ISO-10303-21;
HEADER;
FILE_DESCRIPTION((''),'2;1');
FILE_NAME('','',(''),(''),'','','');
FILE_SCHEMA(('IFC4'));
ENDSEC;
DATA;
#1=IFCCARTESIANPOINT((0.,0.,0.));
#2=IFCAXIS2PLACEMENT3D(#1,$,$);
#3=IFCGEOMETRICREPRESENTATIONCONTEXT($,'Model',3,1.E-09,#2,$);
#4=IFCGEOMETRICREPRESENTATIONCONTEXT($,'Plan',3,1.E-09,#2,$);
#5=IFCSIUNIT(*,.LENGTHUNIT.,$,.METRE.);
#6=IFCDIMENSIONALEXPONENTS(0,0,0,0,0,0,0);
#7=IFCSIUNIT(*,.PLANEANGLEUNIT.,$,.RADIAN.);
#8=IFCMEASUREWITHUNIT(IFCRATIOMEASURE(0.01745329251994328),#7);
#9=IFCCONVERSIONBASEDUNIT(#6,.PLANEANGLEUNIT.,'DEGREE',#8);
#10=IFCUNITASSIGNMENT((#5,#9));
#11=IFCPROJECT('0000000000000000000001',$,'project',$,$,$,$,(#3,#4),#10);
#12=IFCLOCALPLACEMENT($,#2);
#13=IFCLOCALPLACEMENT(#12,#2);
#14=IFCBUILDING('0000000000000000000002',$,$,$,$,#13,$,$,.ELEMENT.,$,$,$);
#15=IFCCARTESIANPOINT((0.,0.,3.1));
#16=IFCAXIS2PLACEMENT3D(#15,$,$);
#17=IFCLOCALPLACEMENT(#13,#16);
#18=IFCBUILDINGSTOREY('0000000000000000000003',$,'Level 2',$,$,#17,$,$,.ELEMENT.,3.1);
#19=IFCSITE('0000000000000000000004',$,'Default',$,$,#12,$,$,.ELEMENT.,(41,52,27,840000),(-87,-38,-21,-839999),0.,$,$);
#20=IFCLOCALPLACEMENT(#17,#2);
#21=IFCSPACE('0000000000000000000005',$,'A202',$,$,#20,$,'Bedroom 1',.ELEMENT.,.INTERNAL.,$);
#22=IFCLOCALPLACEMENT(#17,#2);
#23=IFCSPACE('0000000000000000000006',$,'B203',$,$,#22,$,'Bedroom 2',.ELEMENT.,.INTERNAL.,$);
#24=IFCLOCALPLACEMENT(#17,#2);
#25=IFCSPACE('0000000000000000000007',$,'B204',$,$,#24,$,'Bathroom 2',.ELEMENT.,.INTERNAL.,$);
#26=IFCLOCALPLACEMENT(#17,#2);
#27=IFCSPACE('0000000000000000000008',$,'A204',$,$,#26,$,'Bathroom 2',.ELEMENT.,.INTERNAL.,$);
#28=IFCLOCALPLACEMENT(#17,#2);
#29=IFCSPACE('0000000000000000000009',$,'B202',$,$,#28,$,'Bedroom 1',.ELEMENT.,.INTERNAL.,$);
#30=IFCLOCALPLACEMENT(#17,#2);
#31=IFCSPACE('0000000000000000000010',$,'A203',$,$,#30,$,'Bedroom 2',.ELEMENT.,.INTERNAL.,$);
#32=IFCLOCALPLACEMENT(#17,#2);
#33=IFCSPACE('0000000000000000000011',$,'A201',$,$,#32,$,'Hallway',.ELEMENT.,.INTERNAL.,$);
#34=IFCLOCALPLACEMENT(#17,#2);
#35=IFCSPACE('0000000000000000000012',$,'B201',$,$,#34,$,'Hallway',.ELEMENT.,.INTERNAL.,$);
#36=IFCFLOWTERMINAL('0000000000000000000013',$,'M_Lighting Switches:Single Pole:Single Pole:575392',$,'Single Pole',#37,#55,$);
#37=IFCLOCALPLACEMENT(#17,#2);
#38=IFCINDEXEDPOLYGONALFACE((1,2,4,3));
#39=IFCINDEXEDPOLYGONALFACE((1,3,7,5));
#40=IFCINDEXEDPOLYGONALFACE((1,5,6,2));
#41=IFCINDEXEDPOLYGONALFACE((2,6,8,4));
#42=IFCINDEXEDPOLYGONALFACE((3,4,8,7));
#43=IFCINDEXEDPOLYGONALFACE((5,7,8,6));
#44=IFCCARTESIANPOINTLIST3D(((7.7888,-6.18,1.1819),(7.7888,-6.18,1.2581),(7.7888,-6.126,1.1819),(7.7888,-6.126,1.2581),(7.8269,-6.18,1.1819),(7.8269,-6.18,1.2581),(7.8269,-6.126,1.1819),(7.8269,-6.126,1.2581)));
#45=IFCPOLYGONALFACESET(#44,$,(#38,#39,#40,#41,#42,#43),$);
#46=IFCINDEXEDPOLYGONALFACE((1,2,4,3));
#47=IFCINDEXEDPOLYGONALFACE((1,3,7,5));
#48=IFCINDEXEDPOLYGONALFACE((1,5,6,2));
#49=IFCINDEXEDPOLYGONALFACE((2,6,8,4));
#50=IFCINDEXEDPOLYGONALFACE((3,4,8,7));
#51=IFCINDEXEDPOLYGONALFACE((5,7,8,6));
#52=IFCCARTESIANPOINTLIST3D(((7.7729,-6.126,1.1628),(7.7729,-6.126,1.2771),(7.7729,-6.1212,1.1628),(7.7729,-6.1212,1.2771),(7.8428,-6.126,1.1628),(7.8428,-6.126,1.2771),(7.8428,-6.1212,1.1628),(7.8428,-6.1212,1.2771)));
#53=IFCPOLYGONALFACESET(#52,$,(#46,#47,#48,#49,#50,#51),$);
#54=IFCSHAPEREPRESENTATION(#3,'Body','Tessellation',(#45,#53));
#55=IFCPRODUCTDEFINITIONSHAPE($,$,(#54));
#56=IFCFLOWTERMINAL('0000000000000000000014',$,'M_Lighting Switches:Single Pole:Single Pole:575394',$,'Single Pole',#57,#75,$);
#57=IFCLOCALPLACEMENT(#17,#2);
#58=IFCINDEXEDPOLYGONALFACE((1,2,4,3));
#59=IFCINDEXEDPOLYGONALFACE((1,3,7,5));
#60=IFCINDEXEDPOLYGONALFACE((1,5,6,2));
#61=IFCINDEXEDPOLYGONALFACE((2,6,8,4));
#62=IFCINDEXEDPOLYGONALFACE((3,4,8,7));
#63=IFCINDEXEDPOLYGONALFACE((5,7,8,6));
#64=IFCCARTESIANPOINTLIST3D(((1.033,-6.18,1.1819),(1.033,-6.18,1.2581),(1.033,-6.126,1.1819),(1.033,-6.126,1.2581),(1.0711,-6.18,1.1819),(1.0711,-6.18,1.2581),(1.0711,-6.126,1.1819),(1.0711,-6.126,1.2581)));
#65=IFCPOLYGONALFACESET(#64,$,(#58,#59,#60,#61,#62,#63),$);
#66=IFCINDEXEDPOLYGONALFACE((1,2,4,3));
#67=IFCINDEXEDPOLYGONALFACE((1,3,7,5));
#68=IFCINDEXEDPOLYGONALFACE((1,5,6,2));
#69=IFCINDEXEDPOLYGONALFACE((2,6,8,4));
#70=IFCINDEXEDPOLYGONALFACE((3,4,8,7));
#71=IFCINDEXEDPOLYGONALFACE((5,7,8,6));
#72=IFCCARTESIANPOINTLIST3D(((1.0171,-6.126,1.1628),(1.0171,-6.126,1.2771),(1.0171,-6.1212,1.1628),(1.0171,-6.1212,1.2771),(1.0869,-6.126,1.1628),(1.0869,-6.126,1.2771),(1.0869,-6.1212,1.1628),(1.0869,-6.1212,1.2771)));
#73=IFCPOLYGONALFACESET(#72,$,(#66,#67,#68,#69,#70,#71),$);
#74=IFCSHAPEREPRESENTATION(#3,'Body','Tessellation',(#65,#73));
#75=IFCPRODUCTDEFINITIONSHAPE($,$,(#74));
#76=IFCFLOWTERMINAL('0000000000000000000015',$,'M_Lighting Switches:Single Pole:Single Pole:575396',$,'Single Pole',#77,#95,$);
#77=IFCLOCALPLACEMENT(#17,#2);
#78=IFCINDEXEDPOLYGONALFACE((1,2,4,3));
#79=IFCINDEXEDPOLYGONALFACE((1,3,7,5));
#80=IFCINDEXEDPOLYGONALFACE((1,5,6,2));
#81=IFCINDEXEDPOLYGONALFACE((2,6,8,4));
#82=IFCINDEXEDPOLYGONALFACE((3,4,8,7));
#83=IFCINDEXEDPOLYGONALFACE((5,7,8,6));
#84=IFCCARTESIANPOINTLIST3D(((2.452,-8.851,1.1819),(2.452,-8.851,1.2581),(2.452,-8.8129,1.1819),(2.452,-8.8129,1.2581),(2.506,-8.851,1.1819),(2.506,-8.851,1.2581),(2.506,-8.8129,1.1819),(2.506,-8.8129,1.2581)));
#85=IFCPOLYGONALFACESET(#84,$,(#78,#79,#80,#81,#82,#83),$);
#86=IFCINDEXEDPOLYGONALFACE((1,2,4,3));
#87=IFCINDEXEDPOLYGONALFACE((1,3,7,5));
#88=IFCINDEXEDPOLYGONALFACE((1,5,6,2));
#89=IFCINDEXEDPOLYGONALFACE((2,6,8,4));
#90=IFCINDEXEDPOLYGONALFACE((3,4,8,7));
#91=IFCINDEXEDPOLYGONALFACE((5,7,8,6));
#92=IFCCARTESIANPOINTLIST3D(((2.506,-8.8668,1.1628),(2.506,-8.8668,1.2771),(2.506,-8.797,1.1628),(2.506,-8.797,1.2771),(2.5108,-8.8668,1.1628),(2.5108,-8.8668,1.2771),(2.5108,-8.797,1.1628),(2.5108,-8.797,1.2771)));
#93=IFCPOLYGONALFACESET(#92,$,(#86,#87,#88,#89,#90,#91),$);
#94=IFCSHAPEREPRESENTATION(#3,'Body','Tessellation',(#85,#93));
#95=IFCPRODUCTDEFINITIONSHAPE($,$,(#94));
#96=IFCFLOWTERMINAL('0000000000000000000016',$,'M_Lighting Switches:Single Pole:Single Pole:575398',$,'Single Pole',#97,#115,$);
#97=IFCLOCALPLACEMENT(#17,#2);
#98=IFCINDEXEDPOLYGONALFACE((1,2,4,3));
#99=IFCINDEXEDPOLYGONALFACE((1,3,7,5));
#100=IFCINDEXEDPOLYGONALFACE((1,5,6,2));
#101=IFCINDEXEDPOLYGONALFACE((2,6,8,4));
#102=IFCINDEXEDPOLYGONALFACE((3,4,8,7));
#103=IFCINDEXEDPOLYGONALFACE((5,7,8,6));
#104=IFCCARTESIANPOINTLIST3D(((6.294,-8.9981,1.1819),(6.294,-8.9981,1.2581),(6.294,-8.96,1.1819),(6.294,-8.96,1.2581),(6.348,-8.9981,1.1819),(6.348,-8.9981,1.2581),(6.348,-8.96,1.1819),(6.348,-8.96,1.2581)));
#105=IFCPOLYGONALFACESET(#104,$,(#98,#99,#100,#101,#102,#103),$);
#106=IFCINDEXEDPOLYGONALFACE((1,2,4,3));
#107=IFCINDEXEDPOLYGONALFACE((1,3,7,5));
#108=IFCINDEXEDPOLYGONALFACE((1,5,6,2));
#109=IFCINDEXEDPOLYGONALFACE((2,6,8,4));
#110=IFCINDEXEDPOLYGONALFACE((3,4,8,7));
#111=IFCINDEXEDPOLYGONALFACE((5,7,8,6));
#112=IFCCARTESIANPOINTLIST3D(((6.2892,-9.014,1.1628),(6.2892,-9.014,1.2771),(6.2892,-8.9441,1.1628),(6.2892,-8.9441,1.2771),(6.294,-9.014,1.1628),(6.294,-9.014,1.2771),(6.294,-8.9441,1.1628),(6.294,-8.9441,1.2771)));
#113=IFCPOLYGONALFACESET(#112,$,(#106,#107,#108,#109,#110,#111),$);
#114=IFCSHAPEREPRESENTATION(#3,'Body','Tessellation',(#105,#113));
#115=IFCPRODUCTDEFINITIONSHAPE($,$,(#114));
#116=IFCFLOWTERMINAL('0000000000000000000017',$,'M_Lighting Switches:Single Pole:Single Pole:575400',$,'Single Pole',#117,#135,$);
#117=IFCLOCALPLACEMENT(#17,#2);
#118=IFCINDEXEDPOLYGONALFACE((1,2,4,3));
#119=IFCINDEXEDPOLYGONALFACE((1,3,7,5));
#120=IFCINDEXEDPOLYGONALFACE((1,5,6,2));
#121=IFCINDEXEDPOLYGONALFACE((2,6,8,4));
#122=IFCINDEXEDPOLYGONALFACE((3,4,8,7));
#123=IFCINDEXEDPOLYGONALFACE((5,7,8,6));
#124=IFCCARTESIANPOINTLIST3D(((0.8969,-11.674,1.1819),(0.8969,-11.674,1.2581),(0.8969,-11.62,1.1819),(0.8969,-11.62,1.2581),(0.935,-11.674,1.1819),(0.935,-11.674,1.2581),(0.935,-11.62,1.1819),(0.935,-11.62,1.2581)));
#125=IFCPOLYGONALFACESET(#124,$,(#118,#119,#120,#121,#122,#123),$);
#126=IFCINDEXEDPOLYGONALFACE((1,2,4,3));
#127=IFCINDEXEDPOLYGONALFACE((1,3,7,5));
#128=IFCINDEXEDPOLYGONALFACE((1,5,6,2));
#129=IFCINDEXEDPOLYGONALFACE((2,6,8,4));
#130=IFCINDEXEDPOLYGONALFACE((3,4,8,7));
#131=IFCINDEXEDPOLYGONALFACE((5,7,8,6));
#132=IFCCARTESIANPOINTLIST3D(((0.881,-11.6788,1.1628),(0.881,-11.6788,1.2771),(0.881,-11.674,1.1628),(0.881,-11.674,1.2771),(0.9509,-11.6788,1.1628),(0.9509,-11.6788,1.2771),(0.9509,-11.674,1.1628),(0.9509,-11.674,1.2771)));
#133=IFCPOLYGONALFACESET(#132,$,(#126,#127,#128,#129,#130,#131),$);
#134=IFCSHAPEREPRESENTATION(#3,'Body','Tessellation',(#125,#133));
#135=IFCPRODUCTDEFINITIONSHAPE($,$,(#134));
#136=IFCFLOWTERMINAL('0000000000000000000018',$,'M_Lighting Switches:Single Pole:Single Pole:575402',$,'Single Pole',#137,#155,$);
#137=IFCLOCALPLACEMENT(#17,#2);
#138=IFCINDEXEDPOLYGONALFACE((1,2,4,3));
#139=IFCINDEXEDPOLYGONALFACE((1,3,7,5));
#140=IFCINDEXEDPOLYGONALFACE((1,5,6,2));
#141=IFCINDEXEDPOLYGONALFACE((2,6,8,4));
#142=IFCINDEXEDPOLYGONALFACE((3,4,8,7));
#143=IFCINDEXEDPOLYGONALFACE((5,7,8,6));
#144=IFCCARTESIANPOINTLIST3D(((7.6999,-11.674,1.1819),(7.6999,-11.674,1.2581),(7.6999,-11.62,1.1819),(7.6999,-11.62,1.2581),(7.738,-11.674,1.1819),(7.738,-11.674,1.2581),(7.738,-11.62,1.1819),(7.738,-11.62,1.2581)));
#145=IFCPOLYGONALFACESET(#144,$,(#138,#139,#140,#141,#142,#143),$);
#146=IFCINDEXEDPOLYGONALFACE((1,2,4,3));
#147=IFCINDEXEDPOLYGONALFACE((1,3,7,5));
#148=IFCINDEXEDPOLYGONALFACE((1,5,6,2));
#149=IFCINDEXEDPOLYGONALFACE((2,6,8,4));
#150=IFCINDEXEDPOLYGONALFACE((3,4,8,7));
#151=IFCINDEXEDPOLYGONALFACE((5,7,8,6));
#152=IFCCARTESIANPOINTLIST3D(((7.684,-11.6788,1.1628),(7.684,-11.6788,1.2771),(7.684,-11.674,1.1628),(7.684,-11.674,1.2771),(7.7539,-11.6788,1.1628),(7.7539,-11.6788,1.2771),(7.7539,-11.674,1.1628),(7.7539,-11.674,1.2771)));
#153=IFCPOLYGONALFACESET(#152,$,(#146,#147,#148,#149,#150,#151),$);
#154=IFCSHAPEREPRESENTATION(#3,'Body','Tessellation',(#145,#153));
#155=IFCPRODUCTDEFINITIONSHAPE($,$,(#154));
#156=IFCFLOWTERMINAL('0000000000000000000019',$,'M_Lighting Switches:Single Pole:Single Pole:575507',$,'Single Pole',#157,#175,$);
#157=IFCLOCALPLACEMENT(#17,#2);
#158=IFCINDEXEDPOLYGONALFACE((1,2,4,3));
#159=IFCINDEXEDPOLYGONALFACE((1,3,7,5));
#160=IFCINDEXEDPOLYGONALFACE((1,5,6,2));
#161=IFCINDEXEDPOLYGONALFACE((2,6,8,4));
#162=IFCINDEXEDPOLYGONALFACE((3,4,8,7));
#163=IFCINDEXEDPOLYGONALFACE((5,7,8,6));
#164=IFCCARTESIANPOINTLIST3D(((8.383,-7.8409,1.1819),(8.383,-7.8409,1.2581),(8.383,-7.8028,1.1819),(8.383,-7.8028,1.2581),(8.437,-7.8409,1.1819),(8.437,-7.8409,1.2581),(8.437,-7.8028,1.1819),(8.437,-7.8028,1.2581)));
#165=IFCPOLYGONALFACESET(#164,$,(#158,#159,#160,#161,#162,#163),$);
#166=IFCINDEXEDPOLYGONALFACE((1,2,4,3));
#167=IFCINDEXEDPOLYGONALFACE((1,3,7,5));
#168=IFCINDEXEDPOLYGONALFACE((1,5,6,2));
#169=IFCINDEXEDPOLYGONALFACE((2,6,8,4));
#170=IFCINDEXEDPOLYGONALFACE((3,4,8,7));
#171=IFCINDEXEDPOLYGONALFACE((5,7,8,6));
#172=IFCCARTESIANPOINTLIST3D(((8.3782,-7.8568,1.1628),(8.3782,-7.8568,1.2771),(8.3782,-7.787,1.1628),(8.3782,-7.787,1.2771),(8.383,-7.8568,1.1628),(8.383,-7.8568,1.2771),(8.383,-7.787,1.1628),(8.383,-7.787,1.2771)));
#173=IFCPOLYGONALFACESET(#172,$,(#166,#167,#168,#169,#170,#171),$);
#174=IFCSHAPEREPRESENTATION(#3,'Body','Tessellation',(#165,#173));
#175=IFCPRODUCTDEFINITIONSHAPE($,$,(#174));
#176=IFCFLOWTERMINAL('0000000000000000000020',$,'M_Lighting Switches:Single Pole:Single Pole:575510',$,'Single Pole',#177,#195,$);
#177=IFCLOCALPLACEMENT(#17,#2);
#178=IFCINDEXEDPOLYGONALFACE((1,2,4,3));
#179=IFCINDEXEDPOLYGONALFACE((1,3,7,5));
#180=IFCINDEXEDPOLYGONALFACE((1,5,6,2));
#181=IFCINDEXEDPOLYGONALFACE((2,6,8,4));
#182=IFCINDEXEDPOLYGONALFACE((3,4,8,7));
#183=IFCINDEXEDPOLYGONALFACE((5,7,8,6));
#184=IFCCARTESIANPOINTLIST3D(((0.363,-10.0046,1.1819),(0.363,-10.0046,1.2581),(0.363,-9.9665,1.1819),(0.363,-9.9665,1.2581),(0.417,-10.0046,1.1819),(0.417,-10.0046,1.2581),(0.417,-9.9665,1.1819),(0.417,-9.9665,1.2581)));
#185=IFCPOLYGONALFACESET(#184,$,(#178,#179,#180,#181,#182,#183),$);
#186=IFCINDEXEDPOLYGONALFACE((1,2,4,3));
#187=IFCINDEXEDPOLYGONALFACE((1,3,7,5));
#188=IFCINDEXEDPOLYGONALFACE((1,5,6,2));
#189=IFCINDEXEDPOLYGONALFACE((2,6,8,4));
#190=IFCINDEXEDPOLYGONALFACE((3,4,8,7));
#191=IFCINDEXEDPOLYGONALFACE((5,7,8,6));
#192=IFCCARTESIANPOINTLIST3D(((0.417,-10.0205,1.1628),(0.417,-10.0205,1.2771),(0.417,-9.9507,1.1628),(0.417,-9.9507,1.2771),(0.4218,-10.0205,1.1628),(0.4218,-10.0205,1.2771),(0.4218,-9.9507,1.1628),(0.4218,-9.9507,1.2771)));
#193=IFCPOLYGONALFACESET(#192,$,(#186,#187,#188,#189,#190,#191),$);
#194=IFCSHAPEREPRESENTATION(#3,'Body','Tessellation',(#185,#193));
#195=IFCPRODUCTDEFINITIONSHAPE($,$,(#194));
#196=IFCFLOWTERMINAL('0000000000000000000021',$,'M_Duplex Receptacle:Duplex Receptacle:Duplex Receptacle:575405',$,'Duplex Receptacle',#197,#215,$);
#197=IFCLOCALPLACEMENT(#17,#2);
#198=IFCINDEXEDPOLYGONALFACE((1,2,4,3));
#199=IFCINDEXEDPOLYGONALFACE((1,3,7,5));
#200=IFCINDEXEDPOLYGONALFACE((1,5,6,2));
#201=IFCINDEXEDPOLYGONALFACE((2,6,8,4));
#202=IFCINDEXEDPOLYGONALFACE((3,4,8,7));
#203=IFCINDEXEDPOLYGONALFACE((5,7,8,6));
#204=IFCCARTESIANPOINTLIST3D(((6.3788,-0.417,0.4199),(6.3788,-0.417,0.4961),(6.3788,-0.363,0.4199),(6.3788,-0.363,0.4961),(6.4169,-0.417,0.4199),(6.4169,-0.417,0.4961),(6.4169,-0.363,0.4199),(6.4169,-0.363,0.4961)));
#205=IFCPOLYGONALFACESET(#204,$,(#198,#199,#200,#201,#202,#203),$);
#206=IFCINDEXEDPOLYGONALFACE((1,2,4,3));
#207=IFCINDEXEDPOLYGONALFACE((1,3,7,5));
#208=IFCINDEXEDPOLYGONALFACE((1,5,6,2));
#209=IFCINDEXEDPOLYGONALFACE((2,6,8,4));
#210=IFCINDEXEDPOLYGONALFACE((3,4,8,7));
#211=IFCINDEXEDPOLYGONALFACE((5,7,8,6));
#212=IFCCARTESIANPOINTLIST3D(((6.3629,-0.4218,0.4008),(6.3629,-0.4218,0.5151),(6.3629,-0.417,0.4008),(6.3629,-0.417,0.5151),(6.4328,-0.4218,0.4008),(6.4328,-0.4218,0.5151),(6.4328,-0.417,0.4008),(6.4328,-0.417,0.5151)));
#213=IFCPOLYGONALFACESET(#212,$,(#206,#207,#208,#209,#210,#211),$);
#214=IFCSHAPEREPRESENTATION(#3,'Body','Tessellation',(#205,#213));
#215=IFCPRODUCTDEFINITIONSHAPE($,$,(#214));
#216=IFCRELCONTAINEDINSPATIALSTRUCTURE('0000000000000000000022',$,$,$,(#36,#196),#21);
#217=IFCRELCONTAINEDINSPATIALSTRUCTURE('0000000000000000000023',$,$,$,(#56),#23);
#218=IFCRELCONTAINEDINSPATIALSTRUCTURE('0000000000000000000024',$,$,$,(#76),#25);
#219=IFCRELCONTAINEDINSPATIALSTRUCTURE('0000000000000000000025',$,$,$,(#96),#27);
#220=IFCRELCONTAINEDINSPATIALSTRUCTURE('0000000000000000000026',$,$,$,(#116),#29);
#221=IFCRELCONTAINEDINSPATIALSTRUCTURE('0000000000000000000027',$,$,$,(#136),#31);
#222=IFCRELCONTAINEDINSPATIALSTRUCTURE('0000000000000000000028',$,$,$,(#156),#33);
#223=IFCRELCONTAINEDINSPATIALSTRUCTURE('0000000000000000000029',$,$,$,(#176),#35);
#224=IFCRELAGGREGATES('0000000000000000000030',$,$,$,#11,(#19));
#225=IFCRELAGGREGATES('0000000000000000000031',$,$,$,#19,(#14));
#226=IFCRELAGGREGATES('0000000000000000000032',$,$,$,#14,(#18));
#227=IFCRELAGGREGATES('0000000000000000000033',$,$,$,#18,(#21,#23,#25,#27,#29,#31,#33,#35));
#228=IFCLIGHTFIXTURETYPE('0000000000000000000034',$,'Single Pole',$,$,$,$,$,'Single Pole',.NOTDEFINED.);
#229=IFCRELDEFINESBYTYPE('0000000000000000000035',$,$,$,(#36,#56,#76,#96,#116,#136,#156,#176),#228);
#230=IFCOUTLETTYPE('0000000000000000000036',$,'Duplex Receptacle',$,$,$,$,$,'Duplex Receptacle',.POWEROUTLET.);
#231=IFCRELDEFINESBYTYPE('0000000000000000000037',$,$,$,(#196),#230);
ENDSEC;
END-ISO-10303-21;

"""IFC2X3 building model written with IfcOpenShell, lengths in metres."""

from ifc_helpers import new_model, entity, si_unit, converted_unit, frame, origin, origin_2d_with_axis, place, context, project, spatial, rectangle, extrude, source, transform, mapped, type_object, type_shapes, element, save


model = new_model("IFC2X3")

# Units and contexts
model_context = context("Model", 3, precision=1e-09, world=origin())
plan_context = context("Plan", 3, precision=1e-09, world=origin())
ifc_project = project(units=[si_unit("LENGTHUNIT", "METRE"), converted_unit("PLANEANGLEUNIT", "DEGREE", entity("IfcRatioMeasure", 0.01745329251994328), si_unit("PLANEANGLEUNIT", "RADIAN"), dimensions=[0, 0, 0, 0, 0, 0, 0])], contexts=[model_context, plan_context])

# Site, building, storey, space
site_placement = place(None, origin())
site = spatial("IfcSite", under=ifc_project, at=site_placement, Name="Default", CompositionType="ELEMENT", RefLatitude=(41, 52, 27, 840000), RefLongitude=(-87, -38, -21, -839999), RefElevation=0.0)
building_placement = place(site_placement, origin())
building = spatial("IfcBuilding", under=site, at=building_placement, CompositionType="ELEMENT")
storey_placement = place(building_placement, frame((0.0, 0.0, 3.1)))
storey = spatial("IfcBuildingStorey", under=building, at=storey_placement, Name="Level 2", CompositionType="ELEMENT", Elevation=3.1)
space_1_placement = place(storey_placement, origin())
space_1 = spatial("IfcSpace", under=storey, at=space_1_placement, Name="A202", LongName="Bedroom 1", CompositionType="ELEMENT", InteriorOrExteriorSpace="INTERNAL")

# Flow terminal
light_fixture_type = type_object("IfcLightFixtureType", Name="Single Pole", ElementType="Single Pole", PredefinedType="NOTDEFINED")
shared_shape_1 = source(origin(), model_context, "Body", "SweptSolid", [
    extrude(rectangle(XDim=0.0381, YDim=0.0762, at=origin_2d_with_axis()), frame((0.0, 0.0, -0.054), z_axis=(0.0, 0.0, 1.0), x_axis=(-1.0, 0.0, 0.0)), (0.0, 0.0, 1.0), 0.054),
    extrude(rectangle(XDim=0.0698, YDim=0.1143, at=origin_2d_with_axis()), frame((0.0, 0.0, 0.0), z_axis=(0.0, 0.0, 1.0), x_axis=(-1.0, 0.0, 0.0)), (0.0, 0.0, 1.0), 0.0048),
])
type_shapes(light_fixture_type, [shared_shape_1])
flow_terminal_1_placement = place(space_1_placement, frame((7.8079, -6.126, 1.22), z_axis=(0.0, 1.0, 0.0), x_axis=(-1.0, 0.0, 0.0)))
element("IfcFlowTerminal", 1, at=flow_terminal_1_placement, inside=space_1, type_object=light_fixture_type, Name="M_Lighting Switches:Single Pole:Single Pole:575392", ObjectType="Single Pole", context=model_context, shape_type="MappedRepresentation", body=[
    mapped(shared_shape_1, transform((0.0, 0.0, 0.0), scale=1.0)),
])

# Shared definitions
space_2_placement = place(storey_placement, origin())
space_2 = spatial("IfcSpace", under=storey, at=space_2_placement, Name="B203", LongName="Bedroom 2", CompositionType="ELEMENT", InteriorOrExteriorSpace="INTERNAL")

# Flow terminal
flow_terminal_2_placement = place(space_2_placement, frame((1.052, -6.126, 1.22), z_axis=(0.0, 1.0, 0.0), x_axis=(-1.0, 0.0, 0.0)))
element("IfcFlowTerminal", 2, at=flow_terminal_2_placement, inside=space_2, type_object=light_fixture_type, Name="M_Lighting Switches:Single Pole:Single Pole:575394", ObjectType="Single Pole", context=model_context, shape_type="MappedRepresentation", body=[
    mapped(shared_shape_1, transform((0.0, 0.0, 0.0), scale=1.0)),
])

# Shared definitions
space_3_placement = place(storey_placement, origin())
space_3 = spatial("IfcSpace", under=storey, at=space_3_placement, Name="B204", LongName="Bathroom 2", CompositionType="ELEMENT", InteriorOrExteriorSpace="INTERNAL")

# Flow terminal
flow_terminal_3_placement = place(space_3_placement, frame((2.506, -8.8319, 1.22), z_axis=(1.0, 0.0, 0.0), x_axis=(0.0, 1.0, 0.0)))
element("IfcFlowTerminal", 3, at=flow_terminal_3_placement, inside=space_3, type_object=light_fixture_type, Name="M_Lighting Switches:Single Pole:Single Pole:575396", ObjectType="Single Pole", context=model_context, shape_type="MappedRepresentation", body=[
    mapped(shared_shape_1, transform((0.0, 0.0, 0.0), scale=1.0)),
])

# Shared definitions
space_4_placement = place(storey_placement, origin())
space_4 = spatial("IfcSpace", under=storey, at=space_4_placement, Name="A204", LongName="Bathroom 2", CompositionType="ELEMENT", InteriorOrExteriorSpace="INTERNAL")

# Flow terminal
flow_terminal_4_placement = place(space_4_placement, frame((6.294, -8.9791, 1.22), z_axis=(-1.0, 0.0, 0.0), x_axis=(0.0, -1.0, 0.0)))
element("IfcFlowTerminal", 4, at=flow_terminal_4_placement, inside=space_4, type_object=light_fixture_type, Name="M_Lighting Switches:Single Pole:Single Pole:575398", ObjectType="Single Pole", context=model_context, shape_type="MappedRepresentation", body=[
    mapped(shared_shape_1, transform((0.0, 0.0, 0.0), scale=1.0)),
])

# Shared definitions
space_5_placement = place(storey_placement, origin())
space_5 = spatial("IfcSpace", under=storey, at=space_5_placement, Name="B202", LongName="Bedroom 1", CompositionType="ELEMENT", InteriorOrExteriorSpace="INTERNAL")

# Flow terminal
flow_terminal_5_placement = place(space_5_placement, frame((0.916, -11.674, 1.22), z_axis=(0.0, -1.0, 0.0), x_axis=(1.0, 0.0, 0.0)))
element("IfcFlowTerminal", 5, at=flow_terminal_5_placement, inside=space_5, type_object=light_fixture_type, Name="M_Lighting Switches:Single Pole:Single Pole:575400", ObjectType="Single Pole", context=model_context, shape_type="MappedRepresentation", body=[
    mapped(shared_shape_1, transform((0.0, 0.0, 0.0), scale=1.0)),
])

# Shared definitions
space_6_placement = place(storey_placement, origin())
space_6 = spatial("IfcSpace", under=storey, at=space_6_placement, Name="A203", LongName="Bedroom 2", CompositionType="ELEMENT", InteriorOrExteriorSpace="INTERNAL")

# Flow terminal
flow_terminal_6_placement = place(space_6_placement, frame((7.719, -11.674, 1.22), z_axis=(0.0, -1.0, 0.0), x_axis=(1.0, 0.0, 0.0)))
element("IfcFlowTerminal", 6, at=flow_terminal_6_placement, inside=space_6, type_object=light_fixture_type, Name="M_Lighting Switches:Single Pole:Single Pole:575402", ObjectType="Single Pole", context=model_context, shape_type="MappedRepresentation", body=[
    mapped(shared_shape_1, transform((0.0, 0.0, 0.0), scale=1.0)),
])

# Shared definitions
space_7_placement = place(storey_placement, origin())
space_7 = spatial("IfcSpace", under=storey, at=space_7_placement, Name="A201", LongName="Hallway", CompositionType="ELEMENT", InteriorOrExteriorSpace="INTERNAL")

# Flow terminal
flow_terminal_7_placement = place(space_7_placement, frame((8.383, -7.8219, 1.22), z_axis=(-1.0, 0.0, 0.0), x_axis=(0.0, -1.0, 0.0)))
element("IfcFlowTerminal", 7, at=flow_terminal_7_placement, inside=space_7, type_object=light_fixture_type, Name="M_Lighting Switches:Single Pole:Single Pole:575507", ObjectType="Single Pole", context=model_context, shape_type="MappedRepresentation", body=[
    mapped(shared_shape_1, transform((0.0, 0.0, 0.0), scale=1.0)),
])

# Shared definitions
space_8_placement = place(storey_placement, origin())
space_8 = spatial("IfcSpace", under=storey, at=space_8_placement, Name="B201", LongName="Hallway", CompositionType="ELEMENT", InteriorOrExteriorSpace="INTERNAL")

# Flow terminals
flow_terminal_8_placement = place(space_8_placement, frame((0.417, -9.9856, 1.22), z_axis=(1.0, 0.0, 0.0), x_axis=(0.0, 1.0, 0.0)))
element("IfcFlowTerminal", 8, at=flow_terminal_8_placement, inside=space_8, type_object=light_fixture_type, Name="M_Lighting Switches:Single Pole:Single Pole:575510", ObjectType="Single Pole", context=model_context, shape_type="MappedRepresentation", body=[
    mapped(shared_shape_1, transform((0.0, 0.0, 0.0), scale=1.0)),
])
outlet_type = type_object("IfcOutletType", Name="Duplex Receptacle", ElementType="Duplex Receptacle", PredefinedType="POWEROUTLET")
shared_shape_2 = source(origin(), model_context, "Body", "SweptSolid", [
    extrude(rectangle(XDim=0.0381, YDim=0.0762, at=origin_2d_with_axis()), frame((0.0, 0.0, -0.054), z_axis=(0.0, 0.0, 1.0), x_axis=(-1.0, 0.0, 0.0)), (0.0, 0.0, 1.0), 0.054),
    extrude(rectangle(XDim=0.0698, YDim=0.1143, at=origin_2d_with_axis()), frame((0.0, 0.0, 0.0), z_axis=(0.0, 0.0, 1.0), x_axis=(-1.0, 0.0, 0.0)), (0.0, 0.0, 1.0), 0.0048),
])
type_shapes(outlet_type, [shared_shape_2])
for number, where, z_axis, x_axis, name in (
    (9, (6.3979, -0.417, 0.458), (0.0, -1.0, 0.0), (1.0, 0.0, 0.0), "M_Duplex Receptacle:Duplex Receptacle:Duplex Receptacle:575405"),
):
    element("IfcFlowTerminal", number, at=place(space_1_placement, frame(where, z_axis=z_axis, x_axis=x_axis)), inside=space_1, type_object=outlet_type, Name=name, ObjectType="Duplex Receptacle", context=model_context, shape_type="MappedRepresentation", body=[
        mapped(shared_shape_2, transform((0.0, 0.0, 0.0), scale=1.0)),
    ])

save(model, "model.ifc")
